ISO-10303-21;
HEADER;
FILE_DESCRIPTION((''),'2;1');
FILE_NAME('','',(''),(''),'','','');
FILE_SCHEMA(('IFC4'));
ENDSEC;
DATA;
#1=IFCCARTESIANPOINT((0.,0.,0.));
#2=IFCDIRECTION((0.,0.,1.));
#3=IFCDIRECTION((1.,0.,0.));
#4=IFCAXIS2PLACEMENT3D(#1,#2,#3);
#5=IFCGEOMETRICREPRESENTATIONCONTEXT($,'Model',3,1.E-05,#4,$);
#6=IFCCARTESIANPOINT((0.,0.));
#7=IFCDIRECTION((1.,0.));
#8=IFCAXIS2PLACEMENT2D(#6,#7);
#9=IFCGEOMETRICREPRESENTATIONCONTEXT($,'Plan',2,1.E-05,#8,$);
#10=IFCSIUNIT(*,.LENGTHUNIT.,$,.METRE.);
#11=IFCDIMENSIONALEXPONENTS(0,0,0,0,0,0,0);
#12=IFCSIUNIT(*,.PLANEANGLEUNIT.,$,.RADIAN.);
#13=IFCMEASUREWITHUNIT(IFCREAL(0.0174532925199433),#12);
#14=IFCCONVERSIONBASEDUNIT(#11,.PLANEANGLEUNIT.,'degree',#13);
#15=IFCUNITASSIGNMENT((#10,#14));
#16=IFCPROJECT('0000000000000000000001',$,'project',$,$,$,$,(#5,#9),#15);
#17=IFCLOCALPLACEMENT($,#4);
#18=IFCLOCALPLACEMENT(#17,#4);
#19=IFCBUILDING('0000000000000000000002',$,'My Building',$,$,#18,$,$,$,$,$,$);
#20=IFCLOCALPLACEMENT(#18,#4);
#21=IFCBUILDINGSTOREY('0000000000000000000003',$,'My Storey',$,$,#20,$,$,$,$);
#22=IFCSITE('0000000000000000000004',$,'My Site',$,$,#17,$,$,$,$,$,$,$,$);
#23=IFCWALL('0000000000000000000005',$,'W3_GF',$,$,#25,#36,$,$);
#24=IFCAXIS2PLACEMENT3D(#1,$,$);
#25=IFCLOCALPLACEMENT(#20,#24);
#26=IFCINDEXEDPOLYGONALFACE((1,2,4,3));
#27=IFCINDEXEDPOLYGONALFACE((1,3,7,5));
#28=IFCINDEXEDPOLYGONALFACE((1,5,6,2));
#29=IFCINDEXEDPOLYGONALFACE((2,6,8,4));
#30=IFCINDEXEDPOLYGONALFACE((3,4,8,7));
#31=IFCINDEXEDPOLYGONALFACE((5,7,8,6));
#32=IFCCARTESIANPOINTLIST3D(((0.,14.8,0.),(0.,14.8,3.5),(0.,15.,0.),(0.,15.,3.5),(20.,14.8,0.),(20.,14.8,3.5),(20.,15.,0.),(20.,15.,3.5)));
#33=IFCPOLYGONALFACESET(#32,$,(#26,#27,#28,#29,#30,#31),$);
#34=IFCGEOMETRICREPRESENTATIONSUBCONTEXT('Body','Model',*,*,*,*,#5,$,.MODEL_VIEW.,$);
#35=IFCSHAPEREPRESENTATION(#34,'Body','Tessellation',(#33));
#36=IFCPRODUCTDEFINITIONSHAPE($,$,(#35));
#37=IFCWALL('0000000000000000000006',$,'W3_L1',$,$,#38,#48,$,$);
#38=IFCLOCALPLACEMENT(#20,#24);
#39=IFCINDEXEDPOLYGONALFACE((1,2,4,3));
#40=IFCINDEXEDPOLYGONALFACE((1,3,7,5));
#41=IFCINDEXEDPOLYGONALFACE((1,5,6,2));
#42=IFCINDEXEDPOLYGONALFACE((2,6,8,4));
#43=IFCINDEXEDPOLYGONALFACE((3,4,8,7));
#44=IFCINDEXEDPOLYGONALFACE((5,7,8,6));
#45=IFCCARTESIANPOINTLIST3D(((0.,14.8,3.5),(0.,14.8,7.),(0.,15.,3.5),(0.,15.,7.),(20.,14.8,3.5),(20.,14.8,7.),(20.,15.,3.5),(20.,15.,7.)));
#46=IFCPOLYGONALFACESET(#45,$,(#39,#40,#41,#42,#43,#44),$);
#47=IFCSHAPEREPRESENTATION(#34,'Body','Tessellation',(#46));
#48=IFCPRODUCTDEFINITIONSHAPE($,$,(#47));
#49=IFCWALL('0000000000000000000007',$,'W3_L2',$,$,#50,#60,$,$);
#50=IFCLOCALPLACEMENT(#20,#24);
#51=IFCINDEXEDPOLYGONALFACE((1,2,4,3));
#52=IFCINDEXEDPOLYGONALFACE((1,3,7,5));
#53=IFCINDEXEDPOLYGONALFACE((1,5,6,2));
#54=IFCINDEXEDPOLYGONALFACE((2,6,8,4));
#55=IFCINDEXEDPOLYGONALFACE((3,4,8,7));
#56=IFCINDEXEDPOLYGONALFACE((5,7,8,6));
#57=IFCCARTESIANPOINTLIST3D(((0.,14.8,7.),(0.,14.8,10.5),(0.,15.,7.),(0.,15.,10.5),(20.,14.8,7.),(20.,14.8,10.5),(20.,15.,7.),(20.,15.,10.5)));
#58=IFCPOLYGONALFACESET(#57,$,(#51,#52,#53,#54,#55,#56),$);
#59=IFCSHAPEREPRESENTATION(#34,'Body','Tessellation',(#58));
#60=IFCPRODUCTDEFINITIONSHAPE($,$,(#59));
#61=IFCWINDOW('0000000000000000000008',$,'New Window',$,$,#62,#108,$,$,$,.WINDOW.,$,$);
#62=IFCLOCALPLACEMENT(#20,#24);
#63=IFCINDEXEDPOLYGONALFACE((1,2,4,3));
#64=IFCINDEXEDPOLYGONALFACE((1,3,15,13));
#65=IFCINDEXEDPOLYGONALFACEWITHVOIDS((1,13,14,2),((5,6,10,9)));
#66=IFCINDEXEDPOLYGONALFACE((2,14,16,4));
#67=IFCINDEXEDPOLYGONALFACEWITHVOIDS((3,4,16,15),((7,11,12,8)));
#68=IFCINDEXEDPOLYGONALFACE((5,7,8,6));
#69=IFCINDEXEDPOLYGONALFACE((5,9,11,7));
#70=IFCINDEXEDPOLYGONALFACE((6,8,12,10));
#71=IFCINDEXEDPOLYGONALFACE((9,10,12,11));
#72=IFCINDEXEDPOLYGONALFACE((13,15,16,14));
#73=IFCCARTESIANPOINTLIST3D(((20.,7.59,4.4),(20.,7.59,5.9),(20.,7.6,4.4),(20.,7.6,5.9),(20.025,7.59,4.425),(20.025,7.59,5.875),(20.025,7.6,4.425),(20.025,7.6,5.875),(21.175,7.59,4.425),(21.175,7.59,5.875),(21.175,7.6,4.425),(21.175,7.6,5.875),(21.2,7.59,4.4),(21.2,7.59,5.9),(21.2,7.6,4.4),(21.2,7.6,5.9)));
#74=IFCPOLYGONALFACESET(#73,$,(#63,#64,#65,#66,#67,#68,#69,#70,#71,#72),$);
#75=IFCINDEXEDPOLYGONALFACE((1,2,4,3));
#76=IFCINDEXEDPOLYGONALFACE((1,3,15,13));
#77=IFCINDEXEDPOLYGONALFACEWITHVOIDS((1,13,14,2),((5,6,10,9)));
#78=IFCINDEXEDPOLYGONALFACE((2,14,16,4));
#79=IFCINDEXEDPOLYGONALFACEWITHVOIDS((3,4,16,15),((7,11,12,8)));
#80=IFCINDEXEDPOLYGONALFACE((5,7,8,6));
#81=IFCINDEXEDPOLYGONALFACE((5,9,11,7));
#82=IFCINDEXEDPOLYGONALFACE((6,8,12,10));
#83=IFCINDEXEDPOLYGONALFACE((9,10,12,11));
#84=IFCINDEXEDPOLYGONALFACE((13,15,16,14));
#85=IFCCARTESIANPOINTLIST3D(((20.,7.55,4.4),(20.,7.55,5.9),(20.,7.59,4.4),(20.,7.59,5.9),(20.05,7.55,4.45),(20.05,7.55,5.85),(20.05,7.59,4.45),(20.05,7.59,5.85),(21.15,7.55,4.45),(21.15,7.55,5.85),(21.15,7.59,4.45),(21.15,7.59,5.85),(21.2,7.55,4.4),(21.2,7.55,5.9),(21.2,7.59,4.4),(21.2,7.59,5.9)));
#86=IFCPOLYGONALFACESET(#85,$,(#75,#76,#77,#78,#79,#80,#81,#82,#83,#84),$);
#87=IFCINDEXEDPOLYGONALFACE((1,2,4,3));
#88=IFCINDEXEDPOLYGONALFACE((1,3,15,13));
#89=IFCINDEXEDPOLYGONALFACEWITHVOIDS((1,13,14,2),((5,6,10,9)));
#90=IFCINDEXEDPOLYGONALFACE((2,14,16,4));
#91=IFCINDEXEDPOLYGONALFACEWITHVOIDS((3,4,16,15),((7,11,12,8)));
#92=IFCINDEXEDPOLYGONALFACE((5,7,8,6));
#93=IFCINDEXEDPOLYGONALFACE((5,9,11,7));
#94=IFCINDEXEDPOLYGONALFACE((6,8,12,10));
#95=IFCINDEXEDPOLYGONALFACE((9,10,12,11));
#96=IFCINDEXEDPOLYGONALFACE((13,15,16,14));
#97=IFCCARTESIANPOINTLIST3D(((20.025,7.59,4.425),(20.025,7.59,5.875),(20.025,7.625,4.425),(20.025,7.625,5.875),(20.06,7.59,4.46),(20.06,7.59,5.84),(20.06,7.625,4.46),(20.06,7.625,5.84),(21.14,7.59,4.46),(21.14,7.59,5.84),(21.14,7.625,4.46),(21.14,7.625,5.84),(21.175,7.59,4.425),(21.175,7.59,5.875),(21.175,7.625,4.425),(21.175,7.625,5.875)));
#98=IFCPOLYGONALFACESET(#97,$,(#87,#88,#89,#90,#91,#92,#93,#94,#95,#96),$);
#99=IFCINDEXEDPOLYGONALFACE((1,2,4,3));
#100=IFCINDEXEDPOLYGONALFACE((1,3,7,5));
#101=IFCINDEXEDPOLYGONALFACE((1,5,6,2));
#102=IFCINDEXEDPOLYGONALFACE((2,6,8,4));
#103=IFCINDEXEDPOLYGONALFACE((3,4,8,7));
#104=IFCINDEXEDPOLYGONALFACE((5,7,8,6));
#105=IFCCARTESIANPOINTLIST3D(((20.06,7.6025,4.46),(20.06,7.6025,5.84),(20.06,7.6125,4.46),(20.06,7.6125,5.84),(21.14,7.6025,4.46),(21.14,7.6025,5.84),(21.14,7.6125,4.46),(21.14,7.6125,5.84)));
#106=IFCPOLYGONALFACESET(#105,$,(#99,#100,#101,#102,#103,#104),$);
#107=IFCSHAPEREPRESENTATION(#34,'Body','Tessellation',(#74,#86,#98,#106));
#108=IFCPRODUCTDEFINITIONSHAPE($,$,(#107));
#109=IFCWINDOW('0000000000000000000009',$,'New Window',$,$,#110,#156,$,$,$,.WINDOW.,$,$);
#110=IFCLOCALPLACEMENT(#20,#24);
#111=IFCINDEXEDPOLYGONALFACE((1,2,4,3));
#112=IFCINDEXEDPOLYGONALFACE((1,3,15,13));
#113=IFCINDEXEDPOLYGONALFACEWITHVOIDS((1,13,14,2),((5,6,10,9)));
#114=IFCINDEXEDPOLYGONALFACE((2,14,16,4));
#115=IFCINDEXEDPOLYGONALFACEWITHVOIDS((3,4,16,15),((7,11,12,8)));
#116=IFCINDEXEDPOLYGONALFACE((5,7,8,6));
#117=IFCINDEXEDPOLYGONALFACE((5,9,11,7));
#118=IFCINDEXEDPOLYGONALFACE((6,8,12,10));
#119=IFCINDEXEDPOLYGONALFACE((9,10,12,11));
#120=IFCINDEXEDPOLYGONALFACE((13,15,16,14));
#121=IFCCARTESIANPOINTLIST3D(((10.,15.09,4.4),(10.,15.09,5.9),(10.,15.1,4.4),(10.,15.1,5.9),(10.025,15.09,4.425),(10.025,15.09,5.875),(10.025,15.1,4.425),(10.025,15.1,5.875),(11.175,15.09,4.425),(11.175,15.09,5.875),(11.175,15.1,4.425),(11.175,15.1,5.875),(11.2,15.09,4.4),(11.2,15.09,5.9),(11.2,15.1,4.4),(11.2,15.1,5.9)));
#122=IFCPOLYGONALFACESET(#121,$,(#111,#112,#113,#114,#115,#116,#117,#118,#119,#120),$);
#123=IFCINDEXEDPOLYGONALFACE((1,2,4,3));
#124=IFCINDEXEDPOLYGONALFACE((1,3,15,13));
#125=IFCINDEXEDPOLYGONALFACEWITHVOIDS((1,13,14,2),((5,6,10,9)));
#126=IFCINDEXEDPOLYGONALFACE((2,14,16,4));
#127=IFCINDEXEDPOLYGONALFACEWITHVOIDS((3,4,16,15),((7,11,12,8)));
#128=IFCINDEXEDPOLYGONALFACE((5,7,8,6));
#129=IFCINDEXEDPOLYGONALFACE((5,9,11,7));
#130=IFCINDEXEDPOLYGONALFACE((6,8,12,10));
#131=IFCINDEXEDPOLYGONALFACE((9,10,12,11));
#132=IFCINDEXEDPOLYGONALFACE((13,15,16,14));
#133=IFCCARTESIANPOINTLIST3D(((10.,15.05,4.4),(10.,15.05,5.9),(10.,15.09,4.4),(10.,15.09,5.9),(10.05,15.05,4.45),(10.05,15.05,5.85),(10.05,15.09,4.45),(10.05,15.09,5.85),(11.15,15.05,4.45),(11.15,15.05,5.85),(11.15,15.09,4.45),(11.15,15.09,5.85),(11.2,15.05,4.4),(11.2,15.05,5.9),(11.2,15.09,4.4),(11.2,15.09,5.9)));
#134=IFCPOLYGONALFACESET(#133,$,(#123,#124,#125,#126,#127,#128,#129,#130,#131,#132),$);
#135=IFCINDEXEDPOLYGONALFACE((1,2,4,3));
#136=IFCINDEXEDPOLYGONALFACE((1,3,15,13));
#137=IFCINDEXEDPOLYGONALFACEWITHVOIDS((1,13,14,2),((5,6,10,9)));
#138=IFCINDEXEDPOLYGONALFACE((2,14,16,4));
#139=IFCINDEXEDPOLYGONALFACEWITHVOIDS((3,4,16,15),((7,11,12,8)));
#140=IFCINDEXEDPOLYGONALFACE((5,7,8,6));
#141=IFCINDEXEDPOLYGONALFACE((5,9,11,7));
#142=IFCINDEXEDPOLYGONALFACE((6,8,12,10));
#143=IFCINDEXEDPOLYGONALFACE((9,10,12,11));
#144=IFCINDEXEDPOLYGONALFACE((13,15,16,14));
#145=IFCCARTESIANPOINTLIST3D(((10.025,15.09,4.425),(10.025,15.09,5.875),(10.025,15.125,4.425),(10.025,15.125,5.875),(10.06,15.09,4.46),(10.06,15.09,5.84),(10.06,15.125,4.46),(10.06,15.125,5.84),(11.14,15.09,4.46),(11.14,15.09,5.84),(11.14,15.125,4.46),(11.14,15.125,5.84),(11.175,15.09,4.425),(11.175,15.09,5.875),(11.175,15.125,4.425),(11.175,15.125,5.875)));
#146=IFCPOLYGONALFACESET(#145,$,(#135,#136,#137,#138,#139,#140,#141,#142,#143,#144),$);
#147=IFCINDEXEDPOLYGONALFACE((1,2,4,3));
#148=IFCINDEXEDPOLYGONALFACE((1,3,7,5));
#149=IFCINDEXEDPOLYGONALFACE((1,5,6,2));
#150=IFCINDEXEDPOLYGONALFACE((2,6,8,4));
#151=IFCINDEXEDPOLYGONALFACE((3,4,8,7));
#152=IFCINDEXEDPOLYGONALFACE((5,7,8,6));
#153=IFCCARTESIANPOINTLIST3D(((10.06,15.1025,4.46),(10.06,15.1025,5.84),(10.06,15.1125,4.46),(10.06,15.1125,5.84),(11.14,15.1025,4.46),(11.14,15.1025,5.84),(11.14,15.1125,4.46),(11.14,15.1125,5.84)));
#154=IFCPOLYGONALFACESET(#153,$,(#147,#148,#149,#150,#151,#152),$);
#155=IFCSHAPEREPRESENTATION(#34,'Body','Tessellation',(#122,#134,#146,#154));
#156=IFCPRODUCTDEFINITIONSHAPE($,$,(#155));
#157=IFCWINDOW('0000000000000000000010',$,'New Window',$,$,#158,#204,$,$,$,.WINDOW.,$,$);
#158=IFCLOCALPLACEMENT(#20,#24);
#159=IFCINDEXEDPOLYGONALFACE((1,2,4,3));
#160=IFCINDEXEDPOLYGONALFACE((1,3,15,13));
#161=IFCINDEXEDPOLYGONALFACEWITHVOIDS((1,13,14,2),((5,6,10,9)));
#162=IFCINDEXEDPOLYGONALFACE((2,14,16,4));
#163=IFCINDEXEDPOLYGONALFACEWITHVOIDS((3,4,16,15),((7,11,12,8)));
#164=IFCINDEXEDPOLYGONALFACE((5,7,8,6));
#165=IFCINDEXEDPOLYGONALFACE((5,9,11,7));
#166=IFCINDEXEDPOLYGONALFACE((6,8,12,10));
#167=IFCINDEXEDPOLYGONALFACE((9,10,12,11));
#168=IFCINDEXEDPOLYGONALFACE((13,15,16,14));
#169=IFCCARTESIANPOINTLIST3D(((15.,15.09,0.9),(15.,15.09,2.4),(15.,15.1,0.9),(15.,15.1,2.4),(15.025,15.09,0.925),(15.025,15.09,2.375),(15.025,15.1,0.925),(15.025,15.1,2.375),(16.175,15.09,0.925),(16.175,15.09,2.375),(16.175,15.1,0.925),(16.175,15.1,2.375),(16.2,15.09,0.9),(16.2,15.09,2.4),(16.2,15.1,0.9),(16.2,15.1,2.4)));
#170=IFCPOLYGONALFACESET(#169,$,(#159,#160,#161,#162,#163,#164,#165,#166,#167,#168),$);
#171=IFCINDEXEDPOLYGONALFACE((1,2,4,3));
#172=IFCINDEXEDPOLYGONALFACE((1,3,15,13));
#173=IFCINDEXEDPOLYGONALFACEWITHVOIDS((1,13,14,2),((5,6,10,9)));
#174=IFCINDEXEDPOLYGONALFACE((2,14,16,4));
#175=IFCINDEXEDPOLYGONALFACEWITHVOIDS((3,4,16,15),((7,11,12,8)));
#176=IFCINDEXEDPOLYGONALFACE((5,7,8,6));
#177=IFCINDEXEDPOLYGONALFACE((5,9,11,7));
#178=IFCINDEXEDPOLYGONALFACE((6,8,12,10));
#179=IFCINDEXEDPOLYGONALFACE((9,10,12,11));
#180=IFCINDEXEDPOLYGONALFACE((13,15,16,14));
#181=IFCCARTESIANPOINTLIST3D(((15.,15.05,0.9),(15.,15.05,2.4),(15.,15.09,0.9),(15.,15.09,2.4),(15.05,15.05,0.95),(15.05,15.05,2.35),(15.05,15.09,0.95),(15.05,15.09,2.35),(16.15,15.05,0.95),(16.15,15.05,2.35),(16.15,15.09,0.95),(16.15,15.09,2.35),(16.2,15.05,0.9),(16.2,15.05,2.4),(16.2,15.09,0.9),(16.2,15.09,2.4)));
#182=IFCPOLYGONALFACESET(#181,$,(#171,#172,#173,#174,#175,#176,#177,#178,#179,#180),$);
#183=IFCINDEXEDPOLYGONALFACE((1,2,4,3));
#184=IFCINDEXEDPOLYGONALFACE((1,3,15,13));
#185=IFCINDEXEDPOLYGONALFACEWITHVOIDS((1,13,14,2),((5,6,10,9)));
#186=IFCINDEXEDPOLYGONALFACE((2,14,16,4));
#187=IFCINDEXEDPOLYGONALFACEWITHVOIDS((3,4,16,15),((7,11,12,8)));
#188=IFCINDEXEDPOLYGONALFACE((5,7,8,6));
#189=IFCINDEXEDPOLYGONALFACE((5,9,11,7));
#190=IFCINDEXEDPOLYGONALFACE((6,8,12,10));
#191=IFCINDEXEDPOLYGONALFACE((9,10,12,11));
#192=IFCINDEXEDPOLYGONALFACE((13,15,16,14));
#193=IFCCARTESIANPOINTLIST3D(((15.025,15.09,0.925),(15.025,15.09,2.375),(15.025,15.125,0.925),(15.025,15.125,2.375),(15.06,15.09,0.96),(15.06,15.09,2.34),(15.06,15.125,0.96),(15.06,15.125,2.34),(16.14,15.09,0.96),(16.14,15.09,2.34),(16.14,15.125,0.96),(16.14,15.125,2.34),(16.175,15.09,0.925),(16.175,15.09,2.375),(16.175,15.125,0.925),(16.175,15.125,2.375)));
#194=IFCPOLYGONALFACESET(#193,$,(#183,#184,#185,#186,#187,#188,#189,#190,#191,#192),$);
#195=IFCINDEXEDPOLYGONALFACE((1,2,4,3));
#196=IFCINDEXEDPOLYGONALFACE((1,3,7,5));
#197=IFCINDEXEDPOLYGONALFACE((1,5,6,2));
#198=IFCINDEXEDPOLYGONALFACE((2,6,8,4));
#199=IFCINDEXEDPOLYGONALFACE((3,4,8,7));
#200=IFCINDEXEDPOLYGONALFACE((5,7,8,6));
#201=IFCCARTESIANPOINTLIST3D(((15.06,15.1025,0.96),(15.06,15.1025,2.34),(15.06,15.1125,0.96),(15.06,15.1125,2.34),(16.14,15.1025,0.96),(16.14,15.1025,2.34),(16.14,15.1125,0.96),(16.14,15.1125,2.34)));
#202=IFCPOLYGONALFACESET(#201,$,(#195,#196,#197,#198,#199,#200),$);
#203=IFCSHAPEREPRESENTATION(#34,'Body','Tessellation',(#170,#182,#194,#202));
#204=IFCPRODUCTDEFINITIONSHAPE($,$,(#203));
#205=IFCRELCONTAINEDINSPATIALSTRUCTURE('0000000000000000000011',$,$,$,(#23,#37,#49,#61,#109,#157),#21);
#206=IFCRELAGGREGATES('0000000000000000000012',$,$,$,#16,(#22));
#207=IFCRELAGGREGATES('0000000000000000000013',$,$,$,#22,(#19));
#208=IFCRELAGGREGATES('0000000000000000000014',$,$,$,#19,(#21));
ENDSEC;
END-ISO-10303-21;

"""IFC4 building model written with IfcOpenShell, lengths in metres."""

from ifc_helpers import new_model, entity, si_unit, converted_unit, frame, origin_with_axes, origin_2d_with_axis, place, context, subcontext, project, spatial, line, indexed_curve, outline, extrude, element, save


model = new_model("IFC4")

# Units and contexts
model_context = context("Model", 3, precision=1e-05, world=origin_with_axes())
plan_context = context("Plan", 2, precision=1e-05, world=origin_2d_with_axis())
body_context = subcontext(model_context, "Body", "Model", "MODEL_VIEW")
ifc_project = project(units=[si_unit("LENGTHUNIT", "METRE"), converted_unit("PLANEANGLEUNIT", "degree", entity("IfcReal", 0.0174532925199433), si_unit("PLANEANGLEUNIT", "RADIAN"), dimensions=[0, 0, 0, 0, 0, 0, 0])], contexts=[model_context, plan_context])

# Site, building, storey
site_placement = place(None, origin_with_axes())
site = spatial("IfcSite", under=ifc_project, at=site_placement, Name="My Site")
building_placement = place(site_placement, origin_with_axes())
building = spatial("IfcBuilding", under=site, at=building_placement, Name="My Building")
storey_placement = place(building_placement, origin_with_axes())
storey = spatial("IfcBuildingStorey", under=building, at=storey_placement, Name="My Storey")

# Walls
for number, where, z_axis, x_axis, name in (
    (1, (20.0, 15.0, 0.0), (0.0, 0.0, 1.0), (-1.0, 0.0, 0.0), "W3_GF"),
    (2, (20.0, 15.0, 3.5), (0.0, 0.0, 1.0), (-1.0, 0.0, 0.0), "W3_L1"),
    (3, (20.0, 15.0, 7.0), (0.0, 0.0, 1.0), (-1.0, 0.0, 0.0), "W3_L2"),
):
    element("IfcWall", number, at=place(storey_placement, frame(where, z_axis=z_axis, x_axis=x_axis)), inside=storey, Name=name, context=body_context, shape_type="SweptSolid", body=[
        extrude(outline(indexed_curve([(0.0, 0.0), (0.0, 0.2), (20.0, 0.2), (20.0, 0.0), (0.0, 0.0)], self_intersect=False)), origin_with_axes(), (0.0, 0.0, 1.0), 3.5),
    ])

# Windows
for number, where, z_axis, x_axis, name in (
    (4, (20.0, 7.5, 4.4), (0.0, 0.0, 1.0), (1.0, 0.0, 0.0), "New Window"),
    (5, (10.0, 15.0, 4.4), (0.0, 0.0, 1.0), (1.0, 0.0, 0.0), "New Window"),
):
    element("IfcWindow", number, at=place(storey_placement, frame(where, z_axis=z_axis, x_axis=x_axis)), inside=storey, Name=name, PredefinedType="WINDOW", context=body_context, shape_type="SweptSolid", body=[
        extrude(outline(indexed_curve([(0.0, 0.0), (1.2, 0.0), (1.2, 1.5), (0.0, 1.5)], segments=[line(1, 2, 3, 4, 1)]), holes=[indexed_curve([(0.025, 0.025), (1.175, 0.025), (1.175, 1.475), (0.025, 1.475)], segments=[line(1, 2, 3, 4, 1)])]), frame((0.0, 0.09, 0.0), z_axis=(0.0, -1.0, 0.0), x_axis=(1.0, 0.0, 0.0)), (0.0, 0.0, -1.0), 0.01),
        extrude(outline(indexed_curve([(0.0, 0.0), (1.2, 0.0), (1.2, 1.5), (0.0, 1.5)], segments=[line(1, 2, 3, 4, 1)]), holes=[indexed_curve([(0.05, 0.05), (1.15, 0.05), (1.15, 1.45), (0.05, 1.45)], segments=[line(1, 2, 3, 4, 1)])]), frame((0.0, 0.05, 0.0), z_axis=(0.0, -1.0, 0.0), x_axis=(1.0, 0.0, 0.0)), (0.0, 0.0, -1.0), 0.04),
        extrude(outline(indexed_curve([(0.0, 0.0), (1.15, 0.0), (1.15, 1.45), (0.0, 1.45)], segments=[line(1, 2, 3, 4, 1)]), holes=[indexed_curve([(0.035, 0.035), (1.115, 0.035), (1.115, 1.415), (0.035, 1.415)], segments=[line(1, 2, 3, 4, 1)])]), frame((0.025, 0.09, 0.025), z_axis=(0.0, -1.0, 0.0), x_axis=(1.0, 0.0, 0.0)), (0.0, 0.0, -1.0), 0.035),
        extrude(outline(indexed_curve([(0.035, 0.035), (1.115, 0.035), (1.115, 1.415), (0.035, 1.415)], segments=[line(1, 2, 3, 4, 1)])), frame((0.025, 0.1025, 0.025), z_axis=(0.0, -1.0, 0.0), x_axis=(1.0, 0.0, 0.0)), (0.0, 0.0, -1.0), 0.01),
    ])

# Window
for number, where, z_axis, x_axis, name in (
    (6, (15.0, 15.0, 0.9), (0.0, 0.0, 1.0), (1.0, 0.0, 0.0), "New Window"),
):
    element("IfcWindow", number, at=place(storey_placement, frame(where, z_axis=z_axis, x_axis=x_axis)), inside=storey, Name=name, PredefinedType="WINDOW", context=body_context, shape_type="SweptSolid", body=[
        extrude(outline(indexed_curve([(0.0, 0.0), (1.2, 0.0), (1.2, 1.5), (0.0, 1.5)], segments=[line(1, 2, 3, 4, 1)]), holes=[indexed_curve([(0.025, 0.025), (1.175, 0.025), (1.175, 1.475), (0.025, 1.475)], segments=[line(1, 2, 3, 4, 1)])]), frame((0.0, 0.09, 0.0), z_axis=(0.0, -1.0, 0.0), x_axis=(1.0, 0.0, 0.0)), (0.0, 0.0, -1.0), 0.01),
        extrude(outline(indexed_curve([(0.0, 0.0), (1.2, 0.0), (1.2, 1.5), (0.0, 1.5)], segments=[line(1, 2, 3, 4, 1)]), holes=[indexed_curve([(0.05, 0.05), (1.15, 0.05), (1.15, 1.45), (0.05, 1.45)], segments=[line(1, 2, 3, 4, 1)])]), frame((0.0, 0.05, 0.0), z_axis=(0.0, -1.0, 0.0), x_axis=(1.0, 0.0, 0.0)), (0.0, 0.0, -1.0), 0.04),
        extrude(outline(indexed_curve([(0.0, 0.0), (1.15, 0.0), (1.15, 1.45), (0.0, 1.45)], segments=[line(1, 2, 3, 4, 1)]), holes=[indexed_curve([(0.035, 0.035), (1.115, 0.035), (1.115, 1.415), (0.035, 1.415)], segments=[line(1, 2, 3, 4, 1)])]), frame((0.025, 0.09, 0.025), z_axis=(0.0, -1.0, 0.0), x_axis=(1.0, 0.0, 0.0)), (0.0, 0.0, -1.0), 0.035),
        extrude(outline(indexed_curve([(0.035, 0.035), (1.115, 0.035), (1.115, 1.415), (0.035, 1.415)], segments=[line(1, 2, 3, 4, 1)])), frame((0.025, 0.1025, 0.025), z_axis=(0.0, -1.0, 0.0), x_axis=(1.0, 0.0, 0.0)), (0.0, 0.0, -1.0), 0.01),
    ])

save(model, "model.ifc")
